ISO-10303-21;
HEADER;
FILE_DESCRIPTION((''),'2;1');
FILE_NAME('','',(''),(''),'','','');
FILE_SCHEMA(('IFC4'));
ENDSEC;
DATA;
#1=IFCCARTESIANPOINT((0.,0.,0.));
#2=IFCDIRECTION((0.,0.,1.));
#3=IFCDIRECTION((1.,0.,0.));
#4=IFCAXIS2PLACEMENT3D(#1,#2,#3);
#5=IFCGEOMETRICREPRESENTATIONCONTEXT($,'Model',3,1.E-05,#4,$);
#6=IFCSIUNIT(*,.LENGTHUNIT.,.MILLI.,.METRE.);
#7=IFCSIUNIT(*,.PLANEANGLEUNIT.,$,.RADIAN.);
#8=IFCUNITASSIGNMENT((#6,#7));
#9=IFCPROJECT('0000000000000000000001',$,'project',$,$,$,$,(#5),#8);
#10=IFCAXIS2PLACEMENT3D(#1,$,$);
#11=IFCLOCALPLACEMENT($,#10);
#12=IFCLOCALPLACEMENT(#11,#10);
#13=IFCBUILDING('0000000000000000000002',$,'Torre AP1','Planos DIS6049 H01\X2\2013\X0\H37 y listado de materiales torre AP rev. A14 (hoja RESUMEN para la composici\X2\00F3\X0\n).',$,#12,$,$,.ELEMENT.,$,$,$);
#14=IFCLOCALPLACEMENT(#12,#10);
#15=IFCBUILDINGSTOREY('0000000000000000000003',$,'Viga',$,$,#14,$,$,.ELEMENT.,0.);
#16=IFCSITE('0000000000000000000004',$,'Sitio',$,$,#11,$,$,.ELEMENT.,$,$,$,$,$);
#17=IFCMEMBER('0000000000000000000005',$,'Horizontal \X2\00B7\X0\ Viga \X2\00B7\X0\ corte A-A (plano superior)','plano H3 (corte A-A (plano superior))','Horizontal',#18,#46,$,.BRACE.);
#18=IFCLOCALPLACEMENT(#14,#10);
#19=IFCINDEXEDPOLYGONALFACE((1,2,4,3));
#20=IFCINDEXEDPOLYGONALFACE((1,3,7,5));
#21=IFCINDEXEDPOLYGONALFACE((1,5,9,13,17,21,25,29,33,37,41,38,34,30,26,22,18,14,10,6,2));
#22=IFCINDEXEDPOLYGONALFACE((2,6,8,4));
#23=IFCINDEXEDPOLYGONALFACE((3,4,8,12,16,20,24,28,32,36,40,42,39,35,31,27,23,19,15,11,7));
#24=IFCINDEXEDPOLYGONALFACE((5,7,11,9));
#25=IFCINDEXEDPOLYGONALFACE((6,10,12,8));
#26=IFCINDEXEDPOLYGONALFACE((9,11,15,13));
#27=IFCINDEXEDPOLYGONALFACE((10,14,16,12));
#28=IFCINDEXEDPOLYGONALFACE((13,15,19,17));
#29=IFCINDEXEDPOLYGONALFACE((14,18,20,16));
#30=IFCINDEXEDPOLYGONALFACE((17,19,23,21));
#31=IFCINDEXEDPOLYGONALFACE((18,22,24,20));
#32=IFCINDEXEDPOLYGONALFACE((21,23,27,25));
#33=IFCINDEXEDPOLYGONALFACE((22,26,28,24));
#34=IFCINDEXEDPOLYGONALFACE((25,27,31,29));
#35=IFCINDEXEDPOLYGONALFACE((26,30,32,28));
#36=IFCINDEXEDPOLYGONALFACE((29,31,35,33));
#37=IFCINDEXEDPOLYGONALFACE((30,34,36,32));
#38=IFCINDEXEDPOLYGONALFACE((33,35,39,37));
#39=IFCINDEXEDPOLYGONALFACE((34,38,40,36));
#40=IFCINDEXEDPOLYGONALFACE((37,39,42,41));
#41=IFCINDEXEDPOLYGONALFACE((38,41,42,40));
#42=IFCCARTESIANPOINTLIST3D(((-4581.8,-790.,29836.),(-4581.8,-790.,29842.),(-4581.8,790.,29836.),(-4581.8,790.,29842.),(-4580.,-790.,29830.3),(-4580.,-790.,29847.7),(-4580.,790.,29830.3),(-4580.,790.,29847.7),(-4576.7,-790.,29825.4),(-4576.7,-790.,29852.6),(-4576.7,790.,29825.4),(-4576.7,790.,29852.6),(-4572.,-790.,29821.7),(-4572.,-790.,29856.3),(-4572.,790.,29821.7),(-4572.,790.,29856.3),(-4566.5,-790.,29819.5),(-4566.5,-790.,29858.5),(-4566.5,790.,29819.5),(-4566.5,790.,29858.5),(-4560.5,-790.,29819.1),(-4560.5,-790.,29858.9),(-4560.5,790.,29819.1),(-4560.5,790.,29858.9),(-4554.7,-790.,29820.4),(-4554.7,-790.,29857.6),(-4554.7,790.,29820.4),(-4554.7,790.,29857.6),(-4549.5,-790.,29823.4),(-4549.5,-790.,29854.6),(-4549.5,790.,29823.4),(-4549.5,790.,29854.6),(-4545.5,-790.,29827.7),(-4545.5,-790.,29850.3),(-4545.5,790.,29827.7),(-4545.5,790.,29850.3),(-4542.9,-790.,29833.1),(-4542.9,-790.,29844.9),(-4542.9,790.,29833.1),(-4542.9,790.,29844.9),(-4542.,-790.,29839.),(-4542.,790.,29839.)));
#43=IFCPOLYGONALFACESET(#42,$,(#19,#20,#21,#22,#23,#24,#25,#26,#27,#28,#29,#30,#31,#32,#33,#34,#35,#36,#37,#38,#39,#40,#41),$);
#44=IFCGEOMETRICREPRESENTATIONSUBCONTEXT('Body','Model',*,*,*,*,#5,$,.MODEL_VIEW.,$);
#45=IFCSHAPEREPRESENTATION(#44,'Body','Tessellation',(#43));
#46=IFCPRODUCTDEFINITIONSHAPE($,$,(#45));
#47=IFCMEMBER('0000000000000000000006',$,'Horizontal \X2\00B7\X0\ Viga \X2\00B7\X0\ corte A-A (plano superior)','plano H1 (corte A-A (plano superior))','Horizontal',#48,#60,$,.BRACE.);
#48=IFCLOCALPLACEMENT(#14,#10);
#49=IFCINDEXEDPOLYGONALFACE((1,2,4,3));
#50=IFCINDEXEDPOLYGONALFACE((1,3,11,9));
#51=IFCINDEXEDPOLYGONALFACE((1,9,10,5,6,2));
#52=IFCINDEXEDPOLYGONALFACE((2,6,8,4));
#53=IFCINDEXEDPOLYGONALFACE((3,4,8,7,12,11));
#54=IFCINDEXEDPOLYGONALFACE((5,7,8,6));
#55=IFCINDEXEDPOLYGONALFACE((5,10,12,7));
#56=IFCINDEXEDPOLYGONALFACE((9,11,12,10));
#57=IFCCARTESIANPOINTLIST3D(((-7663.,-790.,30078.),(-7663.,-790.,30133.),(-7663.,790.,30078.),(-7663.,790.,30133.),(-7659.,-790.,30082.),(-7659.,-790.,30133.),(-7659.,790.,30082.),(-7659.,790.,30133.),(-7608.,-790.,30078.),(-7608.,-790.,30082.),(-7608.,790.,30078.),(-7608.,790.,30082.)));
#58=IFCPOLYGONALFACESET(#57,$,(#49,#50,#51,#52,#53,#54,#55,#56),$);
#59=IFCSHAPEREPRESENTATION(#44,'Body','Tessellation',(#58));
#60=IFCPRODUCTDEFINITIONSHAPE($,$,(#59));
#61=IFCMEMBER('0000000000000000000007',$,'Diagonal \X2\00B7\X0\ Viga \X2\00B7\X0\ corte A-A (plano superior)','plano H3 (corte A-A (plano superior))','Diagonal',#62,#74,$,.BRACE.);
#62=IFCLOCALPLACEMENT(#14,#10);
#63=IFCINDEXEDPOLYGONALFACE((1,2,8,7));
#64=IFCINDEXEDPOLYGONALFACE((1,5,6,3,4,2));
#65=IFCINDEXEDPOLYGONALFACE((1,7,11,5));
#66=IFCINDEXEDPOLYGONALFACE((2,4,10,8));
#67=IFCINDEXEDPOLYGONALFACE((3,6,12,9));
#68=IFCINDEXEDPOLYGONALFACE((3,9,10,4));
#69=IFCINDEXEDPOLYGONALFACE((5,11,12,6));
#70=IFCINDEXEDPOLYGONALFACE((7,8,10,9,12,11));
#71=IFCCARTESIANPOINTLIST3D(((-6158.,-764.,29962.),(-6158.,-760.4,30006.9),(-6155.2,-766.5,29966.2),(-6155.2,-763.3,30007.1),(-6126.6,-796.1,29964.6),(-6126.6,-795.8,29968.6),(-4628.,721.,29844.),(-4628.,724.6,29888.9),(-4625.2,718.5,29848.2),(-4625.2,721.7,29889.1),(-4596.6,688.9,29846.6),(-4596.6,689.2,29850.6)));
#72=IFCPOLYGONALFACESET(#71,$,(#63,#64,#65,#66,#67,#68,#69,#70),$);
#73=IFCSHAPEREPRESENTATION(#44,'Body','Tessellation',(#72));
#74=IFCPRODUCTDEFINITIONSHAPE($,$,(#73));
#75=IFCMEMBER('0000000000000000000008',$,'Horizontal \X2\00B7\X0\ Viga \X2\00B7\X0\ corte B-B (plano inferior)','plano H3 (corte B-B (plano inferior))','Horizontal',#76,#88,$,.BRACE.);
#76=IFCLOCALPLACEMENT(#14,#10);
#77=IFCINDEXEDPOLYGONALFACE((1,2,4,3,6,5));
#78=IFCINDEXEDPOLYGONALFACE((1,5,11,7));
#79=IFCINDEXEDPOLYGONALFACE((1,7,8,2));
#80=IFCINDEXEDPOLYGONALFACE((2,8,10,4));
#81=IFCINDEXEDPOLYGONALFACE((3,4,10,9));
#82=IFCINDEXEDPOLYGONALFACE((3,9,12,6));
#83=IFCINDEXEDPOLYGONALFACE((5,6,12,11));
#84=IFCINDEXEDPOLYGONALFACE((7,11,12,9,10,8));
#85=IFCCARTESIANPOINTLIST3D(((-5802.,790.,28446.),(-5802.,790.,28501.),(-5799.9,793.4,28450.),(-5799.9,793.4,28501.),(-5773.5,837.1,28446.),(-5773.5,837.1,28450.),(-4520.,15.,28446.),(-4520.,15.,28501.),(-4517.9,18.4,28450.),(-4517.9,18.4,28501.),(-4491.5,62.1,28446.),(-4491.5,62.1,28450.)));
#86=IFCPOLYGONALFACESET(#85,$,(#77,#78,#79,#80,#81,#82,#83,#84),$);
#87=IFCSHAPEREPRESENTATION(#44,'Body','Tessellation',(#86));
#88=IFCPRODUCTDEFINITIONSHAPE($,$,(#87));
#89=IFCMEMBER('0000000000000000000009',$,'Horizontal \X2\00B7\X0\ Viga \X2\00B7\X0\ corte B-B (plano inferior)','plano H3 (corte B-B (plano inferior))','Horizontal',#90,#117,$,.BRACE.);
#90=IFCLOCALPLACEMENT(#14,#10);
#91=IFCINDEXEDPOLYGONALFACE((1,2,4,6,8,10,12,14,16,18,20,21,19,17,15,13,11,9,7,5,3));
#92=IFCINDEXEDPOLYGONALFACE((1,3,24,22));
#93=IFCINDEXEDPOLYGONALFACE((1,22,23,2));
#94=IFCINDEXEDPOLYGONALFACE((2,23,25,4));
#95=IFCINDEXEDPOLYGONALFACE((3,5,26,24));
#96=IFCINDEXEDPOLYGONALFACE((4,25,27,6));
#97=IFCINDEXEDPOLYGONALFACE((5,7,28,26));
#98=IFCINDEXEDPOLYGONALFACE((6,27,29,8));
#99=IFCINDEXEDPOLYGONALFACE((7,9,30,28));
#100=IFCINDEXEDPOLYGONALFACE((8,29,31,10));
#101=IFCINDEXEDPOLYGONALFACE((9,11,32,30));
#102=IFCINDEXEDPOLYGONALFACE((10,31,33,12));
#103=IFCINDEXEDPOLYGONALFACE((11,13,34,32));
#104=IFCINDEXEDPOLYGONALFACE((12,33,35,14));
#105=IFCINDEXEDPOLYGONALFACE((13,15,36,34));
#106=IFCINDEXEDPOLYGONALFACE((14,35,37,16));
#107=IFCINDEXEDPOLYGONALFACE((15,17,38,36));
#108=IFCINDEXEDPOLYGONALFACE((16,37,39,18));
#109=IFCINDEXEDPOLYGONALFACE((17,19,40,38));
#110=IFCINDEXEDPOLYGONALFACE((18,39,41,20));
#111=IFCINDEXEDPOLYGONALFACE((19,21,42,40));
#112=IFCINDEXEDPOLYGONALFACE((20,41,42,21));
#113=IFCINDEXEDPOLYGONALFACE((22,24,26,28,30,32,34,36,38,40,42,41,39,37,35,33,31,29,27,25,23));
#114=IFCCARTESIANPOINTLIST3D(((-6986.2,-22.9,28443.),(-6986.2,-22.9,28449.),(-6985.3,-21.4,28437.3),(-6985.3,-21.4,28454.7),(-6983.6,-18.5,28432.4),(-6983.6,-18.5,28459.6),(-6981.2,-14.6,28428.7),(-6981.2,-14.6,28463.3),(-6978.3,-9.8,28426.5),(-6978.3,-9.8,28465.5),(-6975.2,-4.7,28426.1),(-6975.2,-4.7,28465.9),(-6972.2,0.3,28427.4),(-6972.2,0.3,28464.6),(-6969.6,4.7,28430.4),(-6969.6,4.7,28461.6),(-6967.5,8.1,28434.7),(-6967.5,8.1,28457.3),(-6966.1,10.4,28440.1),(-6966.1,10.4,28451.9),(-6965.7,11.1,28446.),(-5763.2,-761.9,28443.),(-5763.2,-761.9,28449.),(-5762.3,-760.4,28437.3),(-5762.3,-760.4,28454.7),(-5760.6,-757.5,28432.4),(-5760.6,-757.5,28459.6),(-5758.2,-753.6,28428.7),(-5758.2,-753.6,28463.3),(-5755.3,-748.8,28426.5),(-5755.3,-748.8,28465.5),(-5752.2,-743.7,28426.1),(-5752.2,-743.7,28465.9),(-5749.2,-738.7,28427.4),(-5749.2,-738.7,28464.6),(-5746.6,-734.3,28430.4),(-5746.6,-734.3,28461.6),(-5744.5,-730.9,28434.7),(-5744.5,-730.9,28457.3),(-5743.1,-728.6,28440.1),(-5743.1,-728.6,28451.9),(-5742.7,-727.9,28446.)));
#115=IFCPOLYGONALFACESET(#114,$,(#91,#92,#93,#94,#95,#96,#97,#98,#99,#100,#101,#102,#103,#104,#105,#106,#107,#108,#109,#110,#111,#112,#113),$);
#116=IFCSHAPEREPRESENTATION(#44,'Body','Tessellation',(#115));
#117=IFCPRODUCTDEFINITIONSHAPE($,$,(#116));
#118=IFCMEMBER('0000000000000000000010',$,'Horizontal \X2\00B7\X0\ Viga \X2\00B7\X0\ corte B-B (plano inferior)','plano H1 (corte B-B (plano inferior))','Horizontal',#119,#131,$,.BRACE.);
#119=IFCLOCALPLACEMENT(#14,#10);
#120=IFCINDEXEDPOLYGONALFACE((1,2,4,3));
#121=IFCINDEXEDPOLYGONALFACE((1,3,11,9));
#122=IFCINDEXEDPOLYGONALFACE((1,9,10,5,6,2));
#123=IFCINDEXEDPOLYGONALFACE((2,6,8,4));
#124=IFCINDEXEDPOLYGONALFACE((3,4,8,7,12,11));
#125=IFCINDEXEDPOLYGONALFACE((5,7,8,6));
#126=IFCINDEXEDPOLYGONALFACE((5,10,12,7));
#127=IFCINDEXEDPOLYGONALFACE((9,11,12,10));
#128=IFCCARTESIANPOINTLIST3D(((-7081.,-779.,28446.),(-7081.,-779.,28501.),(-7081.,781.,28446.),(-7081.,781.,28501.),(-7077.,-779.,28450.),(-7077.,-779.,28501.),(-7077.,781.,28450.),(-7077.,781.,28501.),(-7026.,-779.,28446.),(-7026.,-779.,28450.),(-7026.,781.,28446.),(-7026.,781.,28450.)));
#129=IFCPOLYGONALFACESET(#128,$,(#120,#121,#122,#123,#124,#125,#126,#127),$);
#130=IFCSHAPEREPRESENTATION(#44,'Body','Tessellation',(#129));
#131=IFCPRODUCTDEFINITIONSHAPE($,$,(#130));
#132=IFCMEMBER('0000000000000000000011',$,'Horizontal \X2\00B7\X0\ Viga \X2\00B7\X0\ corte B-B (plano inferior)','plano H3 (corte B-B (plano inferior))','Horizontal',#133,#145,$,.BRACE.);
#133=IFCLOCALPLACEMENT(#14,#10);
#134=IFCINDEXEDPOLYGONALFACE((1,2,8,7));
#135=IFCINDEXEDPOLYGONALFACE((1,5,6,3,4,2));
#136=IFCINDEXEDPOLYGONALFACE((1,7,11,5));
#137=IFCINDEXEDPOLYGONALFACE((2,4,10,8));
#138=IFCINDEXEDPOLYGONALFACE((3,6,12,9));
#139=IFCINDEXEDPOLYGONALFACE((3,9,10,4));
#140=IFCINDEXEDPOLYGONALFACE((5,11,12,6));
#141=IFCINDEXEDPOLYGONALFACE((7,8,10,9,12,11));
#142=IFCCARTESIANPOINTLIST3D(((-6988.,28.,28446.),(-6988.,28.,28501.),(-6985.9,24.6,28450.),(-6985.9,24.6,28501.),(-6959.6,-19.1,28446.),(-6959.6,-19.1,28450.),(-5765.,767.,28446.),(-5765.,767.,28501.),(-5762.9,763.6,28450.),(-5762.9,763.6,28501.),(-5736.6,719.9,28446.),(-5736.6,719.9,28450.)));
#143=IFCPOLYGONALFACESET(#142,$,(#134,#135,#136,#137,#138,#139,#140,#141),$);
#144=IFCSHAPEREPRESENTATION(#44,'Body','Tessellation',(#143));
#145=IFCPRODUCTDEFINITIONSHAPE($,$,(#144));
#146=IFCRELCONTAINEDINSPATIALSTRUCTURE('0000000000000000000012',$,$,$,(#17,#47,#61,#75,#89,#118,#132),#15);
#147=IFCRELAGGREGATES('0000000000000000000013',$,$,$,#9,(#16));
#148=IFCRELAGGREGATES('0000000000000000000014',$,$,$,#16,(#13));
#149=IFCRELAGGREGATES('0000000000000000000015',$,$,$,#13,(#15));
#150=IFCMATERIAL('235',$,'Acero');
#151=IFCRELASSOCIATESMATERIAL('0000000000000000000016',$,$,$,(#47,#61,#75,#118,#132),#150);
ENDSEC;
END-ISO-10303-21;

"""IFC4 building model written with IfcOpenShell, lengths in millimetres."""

from ifc_helpers import new_model, si_unit, frame, frame_2d, origin, origin_with_axes, place, context, subcontext, project, spatial, circle, l_section, extrude, material, element, save


model = new_model("IFC4")

# Units and contexts
model_context = context("Model", 3, precision=1e-05, world=origin_with_axes())
body_context = subcontext(model_context, "Body", "Model", "MODEL_VIEW")
ifc_project = project(units=[si_unit("LENGTHUNIT", "METRE", prefix="MILLI"), si_unit("PLANEANGLEUNIT", "RADIAN")], contexts=[model_context])

# Site, building, storey
site_placement = place(None, origin())
site = spatial("IfcSite", under=ifc_project, at=site_placement, Name="Sitio", CompositionType="ELEMENT")
building_placement = place(site_placement, origin())
building = spatial("IfcBuilding", under=site, at=building_placement, Name="Torre AP1", Description="Planos DIS6049 H01–H37 y listado de materiales torre AP rev. A14 (hoja RESUMEN para la composición).", CompositionType="ELEMENT")
storey_placement = place(building_placement, origin())
storey = spatial("IfcBuildingStorey", under=building, at=storey_placement, Name="Viga", CompositionType="ELEMENT", Elevation=0.0)

# Members
ifc_material_1 = material(Name="235", Category="Acero")
member_1_placement = place(storey_placement, frame((-4562.0, 790.0, 29839.0), z_axis=(0.0, -1.0, 0.0), x_axis=(1.0, 0.0, 0.0)))
element("IfcMember", 1, at=member_1_placement, inside=storey, Name="Horizontal · Viga · corte A-A (plano superior)", Description="plano H3 (corte A-A (plano superior))", ObjectType="Horizontal", PredefinedType="BRACE", context=body_context, shape_type="SweptSolid", body=[
    extrude(circle(Radius=20.0), None, (0.0, 0.0, 1.0), 1580.0),
])
member_2_placement = place(storey_placement, frame((-7663.0, 790.0, 30078.0), z_axis=(0.0, -1.0, 0.0), x_axis=(1.0, 0.0, 0.0)))
element("IfcMember", 2, at=member_2_placement, inside=storey, material=ifc_material_1, Name="Horizontal · Viga · corte A-A (plano superior)", Description="plano H1 (corte A-A (plano superior))", ObjectType="Horizontal", PredefinedType="BRACE", context=body_context, shape_type="SweptSolid", body=[
    extrude(l_section(Depth=55.0, Width=55.0, Thickness=4.0, at=frame_2d((27.5, 27.5))), None, (0.0, 0.0, 1.0), 1580.0),
])
member_3_placement = place(storey_placement, frame((-4628.0, 721.0, 29844.0), z_axis=(-0.716484, -0.695411, 0.055258), x_axis=(0.697603, -0.714197, 0.057207)))
element("IfcMember", 3, at=member_3_placement, inside=storey, material=ifc_material_1, Name="Diagonal · Viga · corte A-A (plano superior)", Description="plano H3 (corte A-A (plano superior))", ObjectType="Diagonal", PredefinedType="BRACE", context=body_context, shape_type="SweptSolid", body=[
    extrude(l_section(Depth=45.0, Width=45.0, Thickness=4.0, at=frame_2d((22.5, 22.5))), None, (0.0, 0.0, 1.0), 2135.4),
])
member_4_placement = place(storey_placement, frame((-5802.0, 790.0, 28446.0), z_axis=(0.85578, -0.51734, 0.0), x_axis=(0.51734, 0.85578, 0.0)))
element("IfcMember", 4, at=member_4_placement, inside=storey, material=ifc_material_1, Name="Horizontal · Viga · corte B-B (plano inferior)", Description="plano H3 (corte B-B (plano inferior))", ObjectType="Horizontal", PredefinedType="BRACE", context=body_context, shape_type="SweptSolid", body=[
    extrude(l_section(Depth=55.0, Width=55.0, Thickness=4.0, at=frame_2d((27.5, 27.5))), None, (0.0, 0.0, 1.0), 1498.0),
])
member_5_placement = place(storey_placement, frame((-6976.0, -6.0, 28446.0), z_axis=(0.855883, -0.517169, 0.0), x_axis=(0.517169, 0.855883, 0.0)))
element("IfcMember", 5, at=member_5_placement, inside=storey, Name="Horizontal · Viga · corte B-B (plano inferior)", Description="plano H3 (corte B-B (plano inferior))", ObjectType="Horizontal", PredefinedType="BRACE", context=body_context, shape_type="SweptSolid", body=[
    extrude(circle(Radius=20.0), None, (0.0, 0.0, 1.0), 1428.9),
])
member_6_placement = place(storey_placement, frame((-7081.0, 781.0, 28446.0), z_axis=(0.0, -1.0, 0.0), x_axis=(1.0, 0.0, 0.0)))
element("IfcMember", 6, at=member_6_placement, inside=storey, material=ifc_material_1, Name="Horizontal · Viga · corte B-B (plano inferior)", Description="plano H1 (corte B-B (plano inferior))", ObjectType="Horizontal", PredefinedType="BRACE", context=body_context, shape_type="SweptSolid", body=[
    extrude(l_section(Depth=55.0, Width=55.0, Thickness=4.0, at=frame_2d((27.5, 27.5))), None, (0.0, 0.0, 1.0), 1560.0),
])
member_7_placement = place(storey_placement, frame((-5765.0, 767.0, 28446.0), z_axis=(-0.855883, -0.517169, 0.0), x_axis=(0.517169, -0.855883, 0.0)))
element("IfcMember", 7, at=member_7_placement, inside=storey, material=ifc_material_1, Name="Horizontal · Viga · corte B-B (plano inferior)", Description="plano H3 (corte B-B (plano inferior))", ObjectType="Horizontal", PredefinedType="BRACE", context=body_context, shape_type="SweptSolid", body=[
    extrude(l_section(Depth=55.0, Width=55.0, Thickness=4.0, at=frame_2d((27.5, 27.5))), None, (0.0, 0.0, 1.0), 1428.9),
])

save(model, "model.ifc")
